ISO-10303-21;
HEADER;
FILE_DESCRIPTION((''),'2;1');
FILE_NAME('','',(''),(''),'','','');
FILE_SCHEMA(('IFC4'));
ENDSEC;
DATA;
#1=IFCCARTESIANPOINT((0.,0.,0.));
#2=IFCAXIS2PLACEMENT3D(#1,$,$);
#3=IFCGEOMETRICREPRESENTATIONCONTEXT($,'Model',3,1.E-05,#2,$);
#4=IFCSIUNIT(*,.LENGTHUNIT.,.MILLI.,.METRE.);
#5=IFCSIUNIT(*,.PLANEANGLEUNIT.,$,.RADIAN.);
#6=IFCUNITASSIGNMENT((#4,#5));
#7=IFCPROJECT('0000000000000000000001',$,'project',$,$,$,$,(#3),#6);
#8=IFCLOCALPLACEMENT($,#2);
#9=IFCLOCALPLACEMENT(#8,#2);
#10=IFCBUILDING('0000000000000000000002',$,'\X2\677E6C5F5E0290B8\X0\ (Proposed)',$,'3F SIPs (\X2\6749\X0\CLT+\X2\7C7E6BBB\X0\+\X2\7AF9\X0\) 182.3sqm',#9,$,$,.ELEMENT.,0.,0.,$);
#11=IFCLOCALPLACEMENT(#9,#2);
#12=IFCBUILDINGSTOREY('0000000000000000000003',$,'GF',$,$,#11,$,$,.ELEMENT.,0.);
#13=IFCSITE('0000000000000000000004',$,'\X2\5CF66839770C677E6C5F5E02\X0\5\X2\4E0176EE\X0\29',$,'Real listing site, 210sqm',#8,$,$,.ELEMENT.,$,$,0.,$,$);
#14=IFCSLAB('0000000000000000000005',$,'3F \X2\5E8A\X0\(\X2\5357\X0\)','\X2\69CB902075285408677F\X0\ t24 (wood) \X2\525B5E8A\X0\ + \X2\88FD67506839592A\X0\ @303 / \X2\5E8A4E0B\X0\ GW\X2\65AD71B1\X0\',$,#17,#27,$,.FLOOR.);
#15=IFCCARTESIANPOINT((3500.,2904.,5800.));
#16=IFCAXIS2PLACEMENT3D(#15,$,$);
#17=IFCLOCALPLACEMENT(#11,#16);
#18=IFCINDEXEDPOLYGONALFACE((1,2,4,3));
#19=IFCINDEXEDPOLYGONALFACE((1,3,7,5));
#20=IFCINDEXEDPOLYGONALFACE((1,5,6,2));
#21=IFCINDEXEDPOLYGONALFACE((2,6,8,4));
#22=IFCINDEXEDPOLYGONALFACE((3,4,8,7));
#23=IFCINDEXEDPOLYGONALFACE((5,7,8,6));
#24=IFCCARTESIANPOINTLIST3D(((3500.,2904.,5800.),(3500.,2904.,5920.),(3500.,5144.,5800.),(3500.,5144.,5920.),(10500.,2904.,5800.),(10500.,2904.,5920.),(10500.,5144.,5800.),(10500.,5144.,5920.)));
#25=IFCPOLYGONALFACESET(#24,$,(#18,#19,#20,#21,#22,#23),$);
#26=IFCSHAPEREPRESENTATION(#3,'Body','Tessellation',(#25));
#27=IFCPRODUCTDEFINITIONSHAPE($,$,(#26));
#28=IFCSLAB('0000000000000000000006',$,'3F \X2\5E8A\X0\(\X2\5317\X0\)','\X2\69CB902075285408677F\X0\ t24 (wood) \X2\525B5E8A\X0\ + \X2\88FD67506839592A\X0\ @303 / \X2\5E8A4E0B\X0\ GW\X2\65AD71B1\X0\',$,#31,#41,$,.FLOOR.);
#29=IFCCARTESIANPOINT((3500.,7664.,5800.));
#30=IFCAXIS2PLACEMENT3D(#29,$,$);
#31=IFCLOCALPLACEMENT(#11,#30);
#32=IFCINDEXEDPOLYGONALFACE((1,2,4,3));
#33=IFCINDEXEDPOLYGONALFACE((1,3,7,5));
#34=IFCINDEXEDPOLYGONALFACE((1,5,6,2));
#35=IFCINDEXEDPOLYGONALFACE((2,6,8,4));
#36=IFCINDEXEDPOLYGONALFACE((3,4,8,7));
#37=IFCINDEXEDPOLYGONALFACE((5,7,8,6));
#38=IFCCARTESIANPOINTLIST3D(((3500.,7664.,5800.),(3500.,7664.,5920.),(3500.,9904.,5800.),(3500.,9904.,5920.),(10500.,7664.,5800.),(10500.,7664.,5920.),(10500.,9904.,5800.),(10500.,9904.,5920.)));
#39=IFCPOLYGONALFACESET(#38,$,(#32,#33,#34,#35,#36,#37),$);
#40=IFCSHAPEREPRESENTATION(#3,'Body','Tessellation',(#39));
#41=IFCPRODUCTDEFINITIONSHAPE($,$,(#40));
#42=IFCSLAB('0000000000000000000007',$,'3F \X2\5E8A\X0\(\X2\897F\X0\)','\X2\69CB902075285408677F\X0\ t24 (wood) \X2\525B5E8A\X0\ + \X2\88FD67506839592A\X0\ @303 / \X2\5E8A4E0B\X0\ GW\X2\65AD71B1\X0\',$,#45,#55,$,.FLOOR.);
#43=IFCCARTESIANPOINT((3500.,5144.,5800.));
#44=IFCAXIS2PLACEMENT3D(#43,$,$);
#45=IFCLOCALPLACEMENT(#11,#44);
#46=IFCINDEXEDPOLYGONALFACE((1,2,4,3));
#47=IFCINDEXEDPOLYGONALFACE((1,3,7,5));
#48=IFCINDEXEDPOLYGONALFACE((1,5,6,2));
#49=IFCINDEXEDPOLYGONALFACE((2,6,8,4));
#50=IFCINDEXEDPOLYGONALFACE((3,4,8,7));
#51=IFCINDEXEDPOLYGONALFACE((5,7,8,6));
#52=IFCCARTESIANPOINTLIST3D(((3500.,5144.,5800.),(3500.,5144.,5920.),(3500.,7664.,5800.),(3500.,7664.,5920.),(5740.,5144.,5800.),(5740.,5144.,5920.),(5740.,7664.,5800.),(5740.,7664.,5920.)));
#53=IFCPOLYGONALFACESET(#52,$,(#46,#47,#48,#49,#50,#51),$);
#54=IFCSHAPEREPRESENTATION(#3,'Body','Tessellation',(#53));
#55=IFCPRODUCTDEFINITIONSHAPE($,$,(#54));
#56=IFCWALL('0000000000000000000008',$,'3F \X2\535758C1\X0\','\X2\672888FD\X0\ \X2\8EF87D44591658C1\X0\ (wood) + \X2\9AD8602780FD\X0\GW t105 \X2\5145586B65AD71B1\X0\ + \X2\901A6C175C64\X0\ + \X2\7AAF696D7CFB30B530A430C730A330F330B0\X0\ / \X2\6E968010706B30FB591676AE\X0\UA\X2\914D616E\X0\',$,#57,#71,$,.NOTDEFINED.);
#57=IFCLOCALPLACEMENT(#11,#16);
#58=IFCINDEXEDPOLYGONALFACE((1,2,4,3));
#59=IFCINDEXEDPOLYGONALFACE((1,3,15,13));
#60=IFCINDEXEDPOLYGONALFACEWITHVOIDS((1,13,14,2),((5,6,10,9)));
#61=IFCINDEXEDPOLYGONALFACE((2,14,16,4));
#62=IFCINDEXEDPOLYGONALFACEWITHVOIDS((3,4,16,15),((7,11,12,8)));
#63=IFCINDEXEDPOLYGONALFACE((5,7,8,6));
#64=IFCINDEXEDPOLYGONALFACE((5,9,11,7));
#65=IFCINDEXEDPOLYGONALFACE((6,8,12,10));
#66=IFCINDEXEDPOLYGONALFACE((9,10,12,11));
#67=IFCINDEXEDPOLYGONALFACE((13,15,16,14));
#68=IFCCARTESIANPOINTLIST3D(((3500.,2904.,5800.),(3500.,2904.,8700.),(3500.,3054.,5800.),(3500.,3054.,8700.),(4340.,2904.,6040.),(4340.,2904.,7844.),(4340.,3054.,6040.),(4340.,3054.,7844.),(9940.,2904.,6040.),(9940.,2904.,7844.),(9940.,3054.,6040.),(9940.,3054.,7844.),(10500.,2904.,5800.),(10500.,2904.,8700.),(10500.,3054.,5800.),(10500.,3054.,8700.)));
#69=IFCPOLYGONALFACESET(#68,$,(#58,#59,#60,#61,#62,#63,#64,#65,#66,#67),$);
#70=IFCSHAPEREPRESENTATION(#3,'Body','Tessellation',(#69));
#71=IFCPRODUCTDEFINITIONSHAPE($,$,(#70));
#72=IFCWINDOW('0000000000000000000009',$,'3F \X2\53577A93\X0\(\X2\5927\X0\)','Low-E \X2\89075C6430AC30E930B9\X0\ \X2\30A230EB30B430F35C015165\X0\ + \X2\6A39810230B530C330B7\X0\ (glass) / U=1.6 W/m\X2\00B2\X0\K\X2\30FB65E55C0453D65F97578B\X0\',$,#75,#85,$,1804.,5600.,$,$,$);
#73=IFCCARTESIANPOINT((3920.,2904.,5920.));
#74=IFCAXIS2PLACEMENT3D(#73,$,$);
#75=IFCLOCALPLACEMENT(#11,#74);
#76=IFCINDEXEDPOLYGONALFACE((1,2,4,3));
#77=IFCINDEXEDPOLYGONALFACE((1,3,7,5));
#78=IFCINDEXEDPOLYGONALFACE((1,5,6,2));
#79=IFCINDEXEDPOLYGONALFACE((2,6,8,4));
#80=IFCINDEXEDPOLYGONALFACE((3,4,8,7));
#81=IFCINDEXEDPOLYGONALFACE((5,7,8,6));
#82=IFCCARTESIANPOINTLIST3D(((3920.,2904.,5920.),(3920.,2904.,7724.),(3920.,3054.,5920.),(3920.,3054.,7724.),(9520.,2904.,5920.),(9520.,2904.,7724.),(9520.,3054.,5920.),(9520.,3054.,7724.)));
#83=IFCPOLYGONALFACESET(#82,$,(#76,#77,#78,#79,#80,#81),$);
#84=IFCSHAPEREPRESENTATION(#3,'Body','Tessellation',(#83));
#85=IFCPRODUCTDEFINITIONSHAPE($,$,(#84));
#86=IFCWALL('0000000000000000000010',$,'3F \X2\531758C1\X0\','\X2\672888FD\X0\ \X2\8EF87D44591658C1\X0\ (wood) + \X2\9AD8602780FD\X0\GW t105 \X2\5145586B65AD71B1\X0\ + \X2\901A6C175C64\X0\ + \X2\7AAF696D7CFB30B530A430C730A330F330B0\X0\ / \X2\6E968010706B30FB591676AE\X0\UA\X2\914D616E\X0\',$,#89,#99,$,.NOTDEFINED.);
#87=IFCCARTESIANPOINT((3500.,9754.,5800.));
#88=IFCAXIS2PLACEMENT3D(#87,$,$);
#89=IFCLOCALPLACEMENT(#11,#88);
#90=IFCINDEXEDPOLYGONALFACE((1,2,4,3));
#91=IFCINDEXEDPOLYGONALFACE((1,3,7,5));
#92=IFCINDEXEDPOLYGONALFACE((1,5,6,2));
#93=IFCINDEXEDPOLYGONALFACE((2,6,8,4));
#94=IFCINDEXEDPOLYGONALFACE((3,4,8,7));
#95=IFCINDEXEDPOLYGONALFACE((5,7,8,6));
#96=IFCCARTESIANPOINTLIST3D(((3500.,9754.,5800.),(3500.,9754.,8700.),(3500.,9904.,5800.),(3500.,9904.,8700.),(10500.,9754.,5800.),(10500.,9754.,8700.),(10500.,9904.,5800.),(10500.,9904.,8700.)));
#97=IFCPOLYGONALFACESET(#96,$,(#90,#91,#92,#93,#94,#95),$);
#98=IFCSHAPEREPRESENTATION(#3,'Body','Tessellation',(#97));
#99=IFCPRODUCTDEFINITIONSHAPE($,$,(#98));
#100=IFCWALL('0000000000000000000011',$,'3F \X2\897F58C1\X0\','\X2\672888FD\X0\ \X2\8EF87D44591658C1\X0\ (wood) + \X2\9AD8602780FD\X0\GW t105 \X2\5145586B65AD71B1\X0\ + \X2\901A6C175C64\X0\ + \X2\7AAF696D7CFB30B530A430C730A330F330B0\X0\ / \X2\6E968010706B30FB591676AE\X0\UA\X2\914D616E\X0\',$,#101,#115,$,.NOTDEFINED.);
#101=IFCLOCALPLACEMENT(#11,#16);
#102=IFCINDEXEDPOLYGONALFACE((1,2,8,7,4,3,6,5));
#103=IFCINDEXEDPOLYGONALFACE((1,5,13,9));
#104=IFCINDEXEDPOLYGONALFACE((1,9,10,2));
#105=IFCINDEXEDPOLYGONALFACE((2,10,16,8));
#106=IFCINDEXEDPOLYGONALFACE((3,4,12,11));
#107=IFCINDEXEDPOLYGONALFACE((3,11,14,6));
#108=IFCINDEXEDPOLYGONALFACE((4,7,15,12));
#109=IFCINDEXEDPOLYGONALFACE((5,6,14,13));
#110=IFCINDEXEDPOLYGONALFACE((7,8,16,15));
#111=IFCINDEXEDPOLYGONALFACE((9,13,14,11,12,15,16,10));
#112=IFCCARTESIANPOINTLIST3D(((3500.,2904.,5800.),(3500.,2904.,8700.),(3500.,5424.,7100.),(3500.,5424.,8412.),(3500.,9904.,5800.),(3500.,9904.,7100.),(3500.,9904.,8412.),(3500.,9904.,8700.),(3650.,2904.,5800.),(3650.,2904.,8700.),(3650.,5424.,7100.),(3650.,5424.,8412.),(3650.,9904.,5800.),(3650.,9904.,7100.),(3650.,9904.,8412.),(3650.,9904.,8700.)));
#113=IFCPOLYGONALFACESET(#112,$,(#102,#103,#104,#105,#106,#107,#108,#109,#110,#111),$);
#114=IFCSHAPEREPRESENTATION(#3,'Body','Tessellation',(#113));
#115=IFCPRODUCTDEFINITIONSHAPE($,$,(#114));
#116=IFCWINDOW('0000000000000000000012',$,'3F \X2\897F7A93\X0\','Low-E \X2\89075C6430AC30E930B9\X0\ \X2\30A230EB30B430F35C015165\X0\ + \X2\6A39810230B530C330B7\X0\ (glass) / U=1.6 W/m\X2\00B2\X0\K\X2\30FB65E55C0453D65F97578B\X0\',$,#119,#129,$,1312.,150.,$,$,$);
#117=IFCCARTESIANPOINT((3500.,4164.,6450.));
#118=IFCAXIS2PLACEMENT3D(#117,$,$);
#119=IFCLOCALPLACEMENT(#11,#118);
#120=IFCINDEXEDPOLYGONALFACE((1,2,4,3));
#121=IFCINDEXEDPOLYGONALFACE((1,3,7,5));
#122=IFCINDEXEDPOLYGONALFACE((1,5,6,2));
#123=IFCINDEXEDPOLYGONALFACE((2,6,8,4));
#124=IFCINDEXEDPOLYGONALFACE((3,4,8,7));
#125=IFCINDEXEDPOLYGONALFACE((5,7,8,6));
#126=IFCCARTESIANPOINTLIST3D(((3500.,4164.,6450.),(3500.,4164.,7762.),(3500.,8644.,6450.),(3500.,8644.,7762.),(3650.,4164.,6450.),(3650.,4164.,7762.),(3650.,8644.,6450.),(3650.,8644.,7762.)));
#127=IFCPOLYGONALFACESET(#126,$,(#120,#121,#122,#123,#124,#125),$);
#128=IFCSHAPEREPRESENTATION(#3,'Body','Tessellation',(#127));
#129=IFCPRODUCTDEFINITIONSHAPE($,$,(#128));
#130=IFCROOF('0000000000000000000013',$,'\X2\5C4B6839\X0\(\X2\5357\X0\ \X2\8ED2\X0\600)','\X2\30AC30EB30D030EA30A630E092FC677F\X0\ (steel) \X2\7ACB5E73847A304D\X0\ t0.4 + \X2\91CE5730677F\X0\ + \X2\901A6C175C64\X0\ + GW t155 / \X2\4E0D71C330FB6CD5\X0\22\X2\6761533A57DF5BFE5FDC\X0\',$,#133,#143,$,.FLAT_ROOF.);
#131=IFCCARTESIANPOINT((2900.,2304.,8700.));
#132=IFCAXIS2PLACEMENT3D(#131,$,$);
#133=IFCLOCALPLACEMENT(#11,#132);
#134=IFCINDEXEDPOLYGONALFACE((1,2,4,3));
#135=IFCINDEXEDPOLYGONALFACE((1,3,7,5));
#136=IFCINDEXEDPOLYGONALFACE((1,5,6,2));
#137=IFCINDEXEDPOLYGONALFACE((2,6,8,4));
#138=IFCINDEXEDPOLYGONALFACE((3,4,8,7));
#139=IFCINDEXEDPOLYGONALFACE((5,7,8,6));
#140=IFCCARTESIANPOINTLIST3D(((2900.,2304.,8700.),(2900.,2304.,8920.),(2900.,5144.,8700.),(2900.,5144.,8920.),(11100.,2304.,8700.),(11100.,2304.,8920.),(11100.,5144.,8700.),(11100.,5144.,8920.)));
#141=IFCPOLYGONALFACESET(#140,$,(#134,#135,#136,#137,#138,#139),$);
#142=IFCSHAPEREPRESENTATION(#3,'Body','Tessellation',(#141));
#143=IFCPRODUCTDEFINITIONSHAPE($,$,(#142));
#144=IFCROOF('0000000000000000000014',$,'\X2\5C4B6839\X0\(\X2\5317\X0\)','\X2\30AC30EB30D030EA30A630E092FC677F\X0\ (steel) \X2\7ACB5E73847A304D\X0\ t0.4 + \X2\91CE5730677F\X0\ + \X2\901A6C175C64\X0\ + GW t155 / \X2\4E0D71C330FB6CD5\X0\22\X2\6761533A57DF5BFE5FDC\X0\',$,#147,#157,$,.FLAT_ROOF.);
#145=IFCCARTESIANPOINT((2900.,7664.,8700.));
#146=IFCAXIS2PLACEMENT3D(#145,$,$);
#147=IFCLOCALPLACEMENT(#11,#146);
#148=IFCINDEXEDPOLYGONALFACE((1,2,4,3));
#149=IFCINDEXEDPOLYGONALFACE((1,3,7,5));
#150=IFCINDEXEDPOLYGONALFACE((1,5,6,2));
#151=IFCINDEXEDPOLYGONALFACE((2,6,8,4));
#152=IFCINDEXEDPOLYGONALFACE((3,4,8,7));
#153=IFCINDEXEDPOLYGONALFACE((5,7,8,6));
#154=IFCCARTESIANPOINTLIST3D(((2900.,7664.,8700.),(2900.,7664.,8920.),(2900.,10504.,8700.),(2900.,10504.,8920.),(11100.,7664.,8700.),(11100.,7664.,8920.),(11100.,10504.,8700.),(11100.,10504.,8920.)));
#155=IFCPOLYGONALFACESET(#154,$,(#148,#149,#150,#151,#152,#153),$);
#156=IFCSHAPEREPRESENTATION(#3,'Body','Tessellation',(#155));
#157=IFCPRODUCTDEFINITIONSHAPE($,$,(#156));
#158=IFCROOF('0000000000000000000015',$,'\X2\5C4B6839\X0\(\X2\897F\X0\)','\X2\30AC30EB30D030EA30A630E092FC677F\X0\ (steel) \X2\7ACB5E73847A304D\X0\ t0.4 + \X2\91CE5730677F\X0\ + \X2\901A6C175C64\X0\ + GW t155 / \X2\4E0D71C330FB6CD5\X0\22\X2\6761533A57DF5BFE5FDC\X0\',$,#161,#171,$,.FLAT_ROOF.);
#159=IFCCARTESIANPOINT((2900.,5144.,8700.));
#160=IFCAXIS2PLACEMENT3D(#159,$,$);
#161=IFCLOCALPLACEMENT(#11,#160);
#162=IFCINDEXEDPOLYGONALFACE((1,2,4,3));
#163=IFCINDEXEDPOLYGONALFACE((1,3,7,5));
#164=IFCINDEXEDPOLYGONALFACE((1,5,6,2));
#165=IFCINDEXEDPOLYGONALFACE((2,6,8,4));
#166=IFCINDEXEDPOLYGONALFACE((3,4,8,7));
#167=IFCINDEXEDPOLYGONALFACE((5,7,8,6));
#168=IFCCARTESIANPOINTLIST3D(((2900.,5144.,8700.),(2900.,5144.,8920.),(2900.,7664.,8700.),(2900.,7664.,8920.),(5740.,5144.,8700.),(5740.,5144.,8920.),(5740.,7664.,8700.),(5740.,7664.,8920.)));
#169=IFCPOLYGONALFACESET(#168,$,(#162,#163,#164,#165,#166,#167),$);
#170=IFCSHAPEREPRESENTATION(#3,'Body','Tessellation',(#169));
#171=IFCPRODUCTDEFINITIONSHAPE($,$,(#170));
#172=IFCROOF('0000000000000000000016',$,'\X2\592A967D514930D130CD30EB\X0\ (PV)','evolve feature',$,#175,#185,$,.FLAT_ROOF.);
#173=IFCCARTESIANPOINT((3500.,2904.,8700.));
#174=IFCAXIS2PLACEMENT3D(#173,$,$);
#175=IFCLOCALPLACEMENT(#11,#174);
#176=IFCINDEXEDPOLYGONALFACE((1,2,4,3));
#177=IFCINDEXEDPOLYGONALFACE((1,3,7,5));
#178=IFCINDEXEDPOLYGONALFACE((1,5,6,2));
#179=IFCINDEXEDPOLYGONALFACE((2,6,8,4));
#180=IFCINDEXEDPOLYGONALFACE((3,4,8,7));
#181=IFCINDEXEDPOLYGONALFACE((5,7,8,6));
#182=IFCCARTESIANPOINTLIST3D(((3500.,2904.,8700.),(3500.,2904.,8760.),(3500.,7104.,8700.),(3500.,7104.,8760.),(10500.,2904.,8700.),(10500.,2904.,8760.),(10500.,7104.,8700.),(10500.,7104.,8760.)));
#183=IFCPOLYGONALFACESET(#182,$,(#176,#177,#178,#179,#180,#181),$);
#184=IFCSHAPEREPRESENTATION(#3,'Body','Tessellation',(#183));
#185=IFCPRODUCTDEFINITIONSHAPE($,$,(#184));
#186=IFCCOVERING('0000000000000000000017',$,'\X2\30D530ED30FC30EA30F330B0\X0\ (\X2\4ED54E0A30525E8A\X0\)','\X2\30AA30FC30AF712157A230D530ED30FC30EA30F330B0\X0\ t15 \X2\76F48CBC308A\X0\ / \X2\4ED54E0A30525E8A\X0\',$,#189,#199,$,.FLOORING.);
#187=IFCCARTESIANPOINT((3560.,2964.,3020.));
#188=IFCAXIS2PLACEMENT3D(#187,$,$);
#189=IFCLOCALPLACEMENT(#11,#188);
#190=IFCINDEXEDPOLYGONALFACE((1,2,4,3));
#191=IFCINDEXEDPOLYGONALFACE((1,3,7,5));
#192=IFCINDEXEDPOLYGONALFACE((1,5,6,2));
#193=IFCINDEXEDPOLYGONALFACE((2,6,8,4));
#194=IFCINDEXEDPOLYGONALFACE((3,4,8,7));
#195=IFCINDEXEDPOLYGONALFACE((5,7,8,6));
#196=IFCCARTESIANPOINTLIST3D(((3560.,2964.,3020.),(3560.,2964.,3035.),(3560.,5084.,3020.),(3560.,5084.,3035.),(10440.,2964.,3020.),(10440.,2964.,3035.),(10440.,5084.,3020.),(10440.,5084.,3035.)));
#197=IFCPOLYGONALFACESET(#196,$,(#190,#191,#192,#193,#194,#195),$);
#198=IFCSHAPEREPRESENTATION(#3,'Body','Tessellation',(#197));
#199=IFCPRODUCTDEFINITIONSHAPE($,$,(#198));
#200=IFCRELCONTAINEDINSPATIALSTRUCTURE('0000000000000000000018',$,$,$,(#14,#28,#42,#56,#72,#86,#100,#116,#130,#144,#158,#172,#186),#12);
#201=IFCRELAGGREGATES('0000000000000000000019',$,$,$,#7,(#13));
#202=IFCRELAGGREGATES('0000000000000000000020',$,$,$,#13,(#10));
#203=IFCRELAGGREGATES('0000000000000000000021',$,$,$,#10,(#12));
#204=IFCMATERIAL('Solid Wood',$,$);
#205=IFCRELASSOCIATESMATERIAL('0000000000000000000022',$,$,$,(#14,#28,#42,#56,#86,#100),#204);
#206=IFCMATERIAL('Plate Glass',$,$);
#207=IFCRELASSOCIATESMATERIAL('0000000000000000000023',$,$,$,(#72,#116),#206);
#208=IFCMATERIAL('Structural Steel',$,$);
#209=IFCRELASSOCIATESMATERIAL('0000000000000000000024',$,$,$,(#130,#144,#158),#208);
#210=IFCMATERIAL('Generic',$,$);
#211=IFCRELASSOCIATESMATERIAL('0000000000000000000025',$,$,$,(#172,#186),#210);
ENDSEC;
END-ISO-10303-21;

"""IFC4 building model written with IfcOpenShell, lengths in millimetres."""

from ifc_helpers import new_model, si_unit, frame, frame_2d, origin, place, context, project, spatial, rectangle, extrude, material, element, fill, save


model = new_model("IFC4")

# Units and contexts
model_context = context("Model", 3, precision=1e-05, world=origin())
ifc_project = project(units=[si_unit("LENGTHUNIT", "METRE", prefix="MILLI"), si_unit("PLANEANGLEUNIT", "RADIAN")], contexts=[model_context])

# Site, building, storey
site_placement = place(None, origin())
site = spatial("IfcSite", under=ifc_project, at=site_placement, Name="島根県松江市5丁目29", ObjectType="Real listing site, 210sqm", CompositionType="ELEMENT", RefElevation=0.0)
building_placement = place(site_placement, origin())
building = spatial("IfcBuilding", under=site, at=building_placement, Name="松江市邸 (Proposed)", ObjectType="3F SIPs (杉CLT+籾殻+竹) 182.3sqm", CompositionType="ELEMENT", ElevationOfRefHeight=0.0, ElevationOfTerrain=0.0)
storey_placement = place(building_placement, origin())
storey = spatial("IfcBuildingStorey", under=building, at=storey_placement, Name="GF", CompositionType="ELEMENT", Elevation=0.0)

# Slabs
ifc_material_1 = material(Name="Solid Wood")
slab_1_placement = place(storey_placement, frame((3500.0, 2904.0, 5800.0)))
element("IfcSlab", 1, at=slab_1_placement, inside=storey, material=ifc_material_1, Name="3F 床(南)", Description="構造用合板 t24 (wood) 剛床 + 製材根太 @303 / 床下 GW断熱", PredefinedType="FLOOR", context=model_context, shape_type="SweptSolid", body=[
    extrude(rectangle(XDim=7000.0, YDim=2240.0, at=frame_2d((3500.0, 1120.0))), frame((3500.0, 2904.0, 5800.0)), (0.0, 0.0, 1.0), 120.0),
])
slab_2_placement = place(storey_placement, frame((3500.0, 7664.0, 5800.0)))
element("IfcSlab", 2, at=slab_2_placement, inside=storey, material=ifc_material_1, Name="3F 床(北)", Description="構造用合板 t24 (wood) 剛床 + 製材根太 @303 / 床下 GW断熱", PredefinedType="FLOOR", context=model_context, shape_type="SweptSolid", body=[
    extrude(rectangle(XDim=7000.0, YDim=2240.0, at=frame_2d((3500.0, 1120.0))), frame((3500.0, 7664.0, 5800.0)), (0.0, 0.0, 1.0), 120.0),
])
slab_3_placement = place(storey_placement, frame((3500.0, 5144.0, 5800.0)))
element("IfcSlab", 3, at=slab_3_placement, inside=storey, material=ifc_material_1, Name="3F 床(西)", Description="構造用合板 t24 (wood) 剛床 + 製材根太 @303 / 床下 GW断熱", PredefinedType="FLOOR", context=model_context, shape_type="SweptSolid", body=[
    extrude(rectangle(XDim=2240.0, YDim=2520.0, at=frame_2d((1120.0, 1260.0))), frame((3500.0, 5144.0, 5800.0)), (0.0, 0.0, 1.0), 120.0),
])

# Wall, opening, window
wall_1_placement = place(storey_placement, frame((3500.0, 2904.0, 5800.0)))
wall_1 = element("IfcWall", 4, at=wall_1_placement, inside=storey, material=ifc_material_1, Name="3F 南壁", Description="木製 軸組外壁 (wood) + 高性能GW t105 充填断熱 + 通気層 + 窯業系サイディング / 準耐火・外皮UA配慮", PredefinedType="NOTDEFINED", context=model_context, shape_type="SweptSolid", body=[
    extrude(rectangle(XDim=7000.0, YDim=150.0, at=frame_2d((3500.0, 75.0))), frame((3500.0, 2904.0, 5800.0)), (0.0, 0.0, 1.0), 2900.0),
])
opening_1_placement = place(storey_placement, frame((3920.0, 2904.0, 5920.0)))
opening_1 = element("IfcOpeningElement", 5, at=opening_1_placement, cuts=wall_1, PredefinedType="NOTDEFINED", context=model_context, shape_type="SweptSolid", body=[
    extrude(rectangle(XDim=5600.0, YDim=150.0, at=frame_2d((2800.0, 75.0))), frame((3920.0, 2904.0, 5920.0)), (0.0, 0.0, 1.0), 1804.0),
])
ifc_material_2 = material(Name="Plate Glass")
window_1_placement = place(storey_placement, frame((3920.0, 2904.0, 5920.0)))
window_1 = element("IfcWindow", 6, at=window_1_placement, inside=storey, material=ifc_material_2, Name="3F 南窓(大)", Description="Low-E 複層ガラス アルゴン封入 + 樹脂サッシ (glass) / U=1.6 W/m²K・日射取得型", OverallHeight=1804.0, OverallWidth=5600.0, context=model_context, shape_type="SweptSolid", body=[
    extrude(rectangle(XDim=5600.0, YDim=150.0, at=frame_2d((2800.0, 75.0))), frame((3920.0, 2904.0, 5920.0)), (0.0, 0.0, 1.0), 1804.0),
])
fill(opening_1, window_1)

# Wall
wall_2_placement = place(storey_placement, frame((3500.0, 9754.0, 5800.0)))
element("IfcWall", 7, at=wall_2_placement, inside=storey, material=ifc_material_1, Name="3F 北壁", Description="木製 軸組外壁 (wood) + 高性能GW t105 充填断熱 + 通気層 + 窯業系サイディング / 準耐火・外皮UA配慮", PredefinedType="NOTDEFINED", context=model_context, shape_type="SweptSolid", body=[
    extrude(rectangle(XDim=7000.0, YDim=150.0, at=frame_2d((3500.0, 75.0))), frame((3500.0, 9754.0, 5800.0)), (0.0, 0.0, 1.0), 2900.0),
])

# Wall, opening, window
wall_3_placement = place(storey_placement, frame((3500.0, 2904.0, 5800.0)))
wall_3 = element("IfcWall", 8, at=wall_3_placement, inside=storey, material=ifc_material_1, Name="3F 西壁", Description="木製 軸組外壁 (wood) + 高性能GW t105 充填断熱 + 通気層 + 窯業系サイディング / 準耐火・外皮UA配慮", PredefinedType="NOTDEFINED", context=model_context, shape_type="SweptSolid", body=[
    extrude(rectangle(XDim=150.0, YDim=7000.0, at=frame_2d((75.0, 3500.0))), frame((3500.0, 2904.0, 5800.0)), (0.0, 0.0, 1.0), 2900.0),
])
opening_2_placement = place(storey_placement, frame((3500.0, 4164.0, 6450.0)))
opening_2 = element("IfcOpeningElement", 9, at=opening_2_placement, cuts=wall_3, PredefinedType="NOTDEFINED", context=model_context, shape_type="SweptSolid", body=[
    extrude(rectangle(XDim=150.0, YDim=4480.0, at=frame_2d((75.0, 2240.0))), frame((3500.0, 4164.0, 6450.0)), (0.0, 0.0, 1.0), 1312.0),
])
window_2_placement = place(storey_placement, frame((3500.0, 4164.0, 6450.0)))
window_2 = element("IfcWindow", 10, at=window_2_placement, inside=storey, material=ifc_material_2, Name="3F 西窓", Description="Low-E 複層ガラス アルゴン封入 + 樹脂サッシ (glass) / U=1.6 W/m²K・日射取得型", OverallHeight=1312.0, OverallWidth=150.0, context=model_context, shape_type="SweptSolid", body=[
    extrude(rectangle(XDim=150.0, YDim=4480.0, at=frame_2d((75.0, 2240.0))), frame((3500.0, 4164.0, 6450.0)), (0.0, 0.0, 1.0), 1312.0),
])
fill(opening_2, window_2)

# Roofs
ifc_material_3 = material(Name="Structural Steel")
roof_1_placement = place(storey_placement, frame((2900.0, 2304.0, 8700.0)))
element("IfcRoof", 11, at=roof_1_placement, inside=storey, material=ifc_material_3, Name="屋根(南 軒600)", Description="ガルバリウム鋼板 (steel) 立平葺き t0.4 + 野地板 + 通気層 + GW t155 / 不燃・法22条区域対応", PredefinedType="FLAT_ROOF", context=model_context, shape_type="SweptSolid", body=[
    extrude(rectangle(XDim=8200.0, YDim=2840.0, at=frame_2d((4100.0, 1420.0))), frame((2900.0, 2304.0, 8700.0)), (0.0, 0.0, 1.0), 220.0),
])
roof_2_placement = place(storey_placement, frame((2900.0, 7664.0, 8700.0)))
element("IfcRoof", 12, at=roof_2_placement, inside=storey, material=ifc_material_3, Name="屋根(北)", Description="ガルバリウム鋼板 (steel) 立平葺き t0.4 + 野地板 + 通気層 + GW t155 / 不燃・法22条区域対応", PredefinedType="FLAT_ROOF", context=model_context, shape_type="SweptSolid", body=[
    extrude(rectangle(XDim=8200.0, YDim=2840.0, at=frame_2d((4100.0, 1420.0))), frame((2900.0, 7664.0, 8700.0)), (0.0, 0.0, 1.0), 220.0),
])
roof_3_placement = place(storey_placement, frame((2900.0, 5144.0, 8700.0)))
element("IfcRoof", 13, at=roof_3_placement, inside=storey, material=ifc_material_3, Name="屋根(西)", Description="ガルバリウム鋼板 (steel) 立平葺き t0.4 + 野地板 + 通気層 + GW t155 / 不燃・法22条区域対応", PredefinedType="FLAT_ROOF", context=model_context, shape_type="SweptSolid", body=[
    extrude(rectangle(XDim=2840.0, YDim=2520.0, at=frame_2d((1420.0, 1260.0))), frame((2900.0, 5144.0, 8700.0)), (0.0, 0.0, 1.0), 220.0),
])
ifc_material_4 = material(Name="Generic")
roof_4_placement = place(storey_placement, frame((3500.0, 2904.0, 8700.0)))
element("IfcRoof", 14, at=roof_4_placement, inside=storey, material=ifc_material_4, Name="太陽光パネル (PV)", Description="evolve feature", PredefinedType="FLAT_ROOF", context=model_context, shape_type="SweptSolid", body=[
    extrude(rectangle(XDim=7000.0, YDim=4200.0, at=frame_2d((3500.0, 2100.0))), frame((3500.0, 2904.0, 8700.0)), (0.0, 0.0, 1.0), 60.0),
])

# Covering
covering_1_placement = place(storey_placement, frame((3560.0, 2964.0, 3020.0)))
element("IfcCovering", 15, at=covering_1_placement, inside=storey, material=ifc_material_4, Name="フローリング (仕上げ床)", Description="オーク無垢フローリング t15 直貼り / 仕上げ床", PredefinedType="FLOORING", context=model_context, shape_type="SweptSolid", body=[
    extrude(rectangle(XDim=6880.0, YDim=2120.0, at=frame_2d((3440.0, 1060.0))), frame((3560.0, 2964.0, 3020.0)), (0.0, 0.0, 1.0), 15.0),
])

save(model, "model.ifc")
